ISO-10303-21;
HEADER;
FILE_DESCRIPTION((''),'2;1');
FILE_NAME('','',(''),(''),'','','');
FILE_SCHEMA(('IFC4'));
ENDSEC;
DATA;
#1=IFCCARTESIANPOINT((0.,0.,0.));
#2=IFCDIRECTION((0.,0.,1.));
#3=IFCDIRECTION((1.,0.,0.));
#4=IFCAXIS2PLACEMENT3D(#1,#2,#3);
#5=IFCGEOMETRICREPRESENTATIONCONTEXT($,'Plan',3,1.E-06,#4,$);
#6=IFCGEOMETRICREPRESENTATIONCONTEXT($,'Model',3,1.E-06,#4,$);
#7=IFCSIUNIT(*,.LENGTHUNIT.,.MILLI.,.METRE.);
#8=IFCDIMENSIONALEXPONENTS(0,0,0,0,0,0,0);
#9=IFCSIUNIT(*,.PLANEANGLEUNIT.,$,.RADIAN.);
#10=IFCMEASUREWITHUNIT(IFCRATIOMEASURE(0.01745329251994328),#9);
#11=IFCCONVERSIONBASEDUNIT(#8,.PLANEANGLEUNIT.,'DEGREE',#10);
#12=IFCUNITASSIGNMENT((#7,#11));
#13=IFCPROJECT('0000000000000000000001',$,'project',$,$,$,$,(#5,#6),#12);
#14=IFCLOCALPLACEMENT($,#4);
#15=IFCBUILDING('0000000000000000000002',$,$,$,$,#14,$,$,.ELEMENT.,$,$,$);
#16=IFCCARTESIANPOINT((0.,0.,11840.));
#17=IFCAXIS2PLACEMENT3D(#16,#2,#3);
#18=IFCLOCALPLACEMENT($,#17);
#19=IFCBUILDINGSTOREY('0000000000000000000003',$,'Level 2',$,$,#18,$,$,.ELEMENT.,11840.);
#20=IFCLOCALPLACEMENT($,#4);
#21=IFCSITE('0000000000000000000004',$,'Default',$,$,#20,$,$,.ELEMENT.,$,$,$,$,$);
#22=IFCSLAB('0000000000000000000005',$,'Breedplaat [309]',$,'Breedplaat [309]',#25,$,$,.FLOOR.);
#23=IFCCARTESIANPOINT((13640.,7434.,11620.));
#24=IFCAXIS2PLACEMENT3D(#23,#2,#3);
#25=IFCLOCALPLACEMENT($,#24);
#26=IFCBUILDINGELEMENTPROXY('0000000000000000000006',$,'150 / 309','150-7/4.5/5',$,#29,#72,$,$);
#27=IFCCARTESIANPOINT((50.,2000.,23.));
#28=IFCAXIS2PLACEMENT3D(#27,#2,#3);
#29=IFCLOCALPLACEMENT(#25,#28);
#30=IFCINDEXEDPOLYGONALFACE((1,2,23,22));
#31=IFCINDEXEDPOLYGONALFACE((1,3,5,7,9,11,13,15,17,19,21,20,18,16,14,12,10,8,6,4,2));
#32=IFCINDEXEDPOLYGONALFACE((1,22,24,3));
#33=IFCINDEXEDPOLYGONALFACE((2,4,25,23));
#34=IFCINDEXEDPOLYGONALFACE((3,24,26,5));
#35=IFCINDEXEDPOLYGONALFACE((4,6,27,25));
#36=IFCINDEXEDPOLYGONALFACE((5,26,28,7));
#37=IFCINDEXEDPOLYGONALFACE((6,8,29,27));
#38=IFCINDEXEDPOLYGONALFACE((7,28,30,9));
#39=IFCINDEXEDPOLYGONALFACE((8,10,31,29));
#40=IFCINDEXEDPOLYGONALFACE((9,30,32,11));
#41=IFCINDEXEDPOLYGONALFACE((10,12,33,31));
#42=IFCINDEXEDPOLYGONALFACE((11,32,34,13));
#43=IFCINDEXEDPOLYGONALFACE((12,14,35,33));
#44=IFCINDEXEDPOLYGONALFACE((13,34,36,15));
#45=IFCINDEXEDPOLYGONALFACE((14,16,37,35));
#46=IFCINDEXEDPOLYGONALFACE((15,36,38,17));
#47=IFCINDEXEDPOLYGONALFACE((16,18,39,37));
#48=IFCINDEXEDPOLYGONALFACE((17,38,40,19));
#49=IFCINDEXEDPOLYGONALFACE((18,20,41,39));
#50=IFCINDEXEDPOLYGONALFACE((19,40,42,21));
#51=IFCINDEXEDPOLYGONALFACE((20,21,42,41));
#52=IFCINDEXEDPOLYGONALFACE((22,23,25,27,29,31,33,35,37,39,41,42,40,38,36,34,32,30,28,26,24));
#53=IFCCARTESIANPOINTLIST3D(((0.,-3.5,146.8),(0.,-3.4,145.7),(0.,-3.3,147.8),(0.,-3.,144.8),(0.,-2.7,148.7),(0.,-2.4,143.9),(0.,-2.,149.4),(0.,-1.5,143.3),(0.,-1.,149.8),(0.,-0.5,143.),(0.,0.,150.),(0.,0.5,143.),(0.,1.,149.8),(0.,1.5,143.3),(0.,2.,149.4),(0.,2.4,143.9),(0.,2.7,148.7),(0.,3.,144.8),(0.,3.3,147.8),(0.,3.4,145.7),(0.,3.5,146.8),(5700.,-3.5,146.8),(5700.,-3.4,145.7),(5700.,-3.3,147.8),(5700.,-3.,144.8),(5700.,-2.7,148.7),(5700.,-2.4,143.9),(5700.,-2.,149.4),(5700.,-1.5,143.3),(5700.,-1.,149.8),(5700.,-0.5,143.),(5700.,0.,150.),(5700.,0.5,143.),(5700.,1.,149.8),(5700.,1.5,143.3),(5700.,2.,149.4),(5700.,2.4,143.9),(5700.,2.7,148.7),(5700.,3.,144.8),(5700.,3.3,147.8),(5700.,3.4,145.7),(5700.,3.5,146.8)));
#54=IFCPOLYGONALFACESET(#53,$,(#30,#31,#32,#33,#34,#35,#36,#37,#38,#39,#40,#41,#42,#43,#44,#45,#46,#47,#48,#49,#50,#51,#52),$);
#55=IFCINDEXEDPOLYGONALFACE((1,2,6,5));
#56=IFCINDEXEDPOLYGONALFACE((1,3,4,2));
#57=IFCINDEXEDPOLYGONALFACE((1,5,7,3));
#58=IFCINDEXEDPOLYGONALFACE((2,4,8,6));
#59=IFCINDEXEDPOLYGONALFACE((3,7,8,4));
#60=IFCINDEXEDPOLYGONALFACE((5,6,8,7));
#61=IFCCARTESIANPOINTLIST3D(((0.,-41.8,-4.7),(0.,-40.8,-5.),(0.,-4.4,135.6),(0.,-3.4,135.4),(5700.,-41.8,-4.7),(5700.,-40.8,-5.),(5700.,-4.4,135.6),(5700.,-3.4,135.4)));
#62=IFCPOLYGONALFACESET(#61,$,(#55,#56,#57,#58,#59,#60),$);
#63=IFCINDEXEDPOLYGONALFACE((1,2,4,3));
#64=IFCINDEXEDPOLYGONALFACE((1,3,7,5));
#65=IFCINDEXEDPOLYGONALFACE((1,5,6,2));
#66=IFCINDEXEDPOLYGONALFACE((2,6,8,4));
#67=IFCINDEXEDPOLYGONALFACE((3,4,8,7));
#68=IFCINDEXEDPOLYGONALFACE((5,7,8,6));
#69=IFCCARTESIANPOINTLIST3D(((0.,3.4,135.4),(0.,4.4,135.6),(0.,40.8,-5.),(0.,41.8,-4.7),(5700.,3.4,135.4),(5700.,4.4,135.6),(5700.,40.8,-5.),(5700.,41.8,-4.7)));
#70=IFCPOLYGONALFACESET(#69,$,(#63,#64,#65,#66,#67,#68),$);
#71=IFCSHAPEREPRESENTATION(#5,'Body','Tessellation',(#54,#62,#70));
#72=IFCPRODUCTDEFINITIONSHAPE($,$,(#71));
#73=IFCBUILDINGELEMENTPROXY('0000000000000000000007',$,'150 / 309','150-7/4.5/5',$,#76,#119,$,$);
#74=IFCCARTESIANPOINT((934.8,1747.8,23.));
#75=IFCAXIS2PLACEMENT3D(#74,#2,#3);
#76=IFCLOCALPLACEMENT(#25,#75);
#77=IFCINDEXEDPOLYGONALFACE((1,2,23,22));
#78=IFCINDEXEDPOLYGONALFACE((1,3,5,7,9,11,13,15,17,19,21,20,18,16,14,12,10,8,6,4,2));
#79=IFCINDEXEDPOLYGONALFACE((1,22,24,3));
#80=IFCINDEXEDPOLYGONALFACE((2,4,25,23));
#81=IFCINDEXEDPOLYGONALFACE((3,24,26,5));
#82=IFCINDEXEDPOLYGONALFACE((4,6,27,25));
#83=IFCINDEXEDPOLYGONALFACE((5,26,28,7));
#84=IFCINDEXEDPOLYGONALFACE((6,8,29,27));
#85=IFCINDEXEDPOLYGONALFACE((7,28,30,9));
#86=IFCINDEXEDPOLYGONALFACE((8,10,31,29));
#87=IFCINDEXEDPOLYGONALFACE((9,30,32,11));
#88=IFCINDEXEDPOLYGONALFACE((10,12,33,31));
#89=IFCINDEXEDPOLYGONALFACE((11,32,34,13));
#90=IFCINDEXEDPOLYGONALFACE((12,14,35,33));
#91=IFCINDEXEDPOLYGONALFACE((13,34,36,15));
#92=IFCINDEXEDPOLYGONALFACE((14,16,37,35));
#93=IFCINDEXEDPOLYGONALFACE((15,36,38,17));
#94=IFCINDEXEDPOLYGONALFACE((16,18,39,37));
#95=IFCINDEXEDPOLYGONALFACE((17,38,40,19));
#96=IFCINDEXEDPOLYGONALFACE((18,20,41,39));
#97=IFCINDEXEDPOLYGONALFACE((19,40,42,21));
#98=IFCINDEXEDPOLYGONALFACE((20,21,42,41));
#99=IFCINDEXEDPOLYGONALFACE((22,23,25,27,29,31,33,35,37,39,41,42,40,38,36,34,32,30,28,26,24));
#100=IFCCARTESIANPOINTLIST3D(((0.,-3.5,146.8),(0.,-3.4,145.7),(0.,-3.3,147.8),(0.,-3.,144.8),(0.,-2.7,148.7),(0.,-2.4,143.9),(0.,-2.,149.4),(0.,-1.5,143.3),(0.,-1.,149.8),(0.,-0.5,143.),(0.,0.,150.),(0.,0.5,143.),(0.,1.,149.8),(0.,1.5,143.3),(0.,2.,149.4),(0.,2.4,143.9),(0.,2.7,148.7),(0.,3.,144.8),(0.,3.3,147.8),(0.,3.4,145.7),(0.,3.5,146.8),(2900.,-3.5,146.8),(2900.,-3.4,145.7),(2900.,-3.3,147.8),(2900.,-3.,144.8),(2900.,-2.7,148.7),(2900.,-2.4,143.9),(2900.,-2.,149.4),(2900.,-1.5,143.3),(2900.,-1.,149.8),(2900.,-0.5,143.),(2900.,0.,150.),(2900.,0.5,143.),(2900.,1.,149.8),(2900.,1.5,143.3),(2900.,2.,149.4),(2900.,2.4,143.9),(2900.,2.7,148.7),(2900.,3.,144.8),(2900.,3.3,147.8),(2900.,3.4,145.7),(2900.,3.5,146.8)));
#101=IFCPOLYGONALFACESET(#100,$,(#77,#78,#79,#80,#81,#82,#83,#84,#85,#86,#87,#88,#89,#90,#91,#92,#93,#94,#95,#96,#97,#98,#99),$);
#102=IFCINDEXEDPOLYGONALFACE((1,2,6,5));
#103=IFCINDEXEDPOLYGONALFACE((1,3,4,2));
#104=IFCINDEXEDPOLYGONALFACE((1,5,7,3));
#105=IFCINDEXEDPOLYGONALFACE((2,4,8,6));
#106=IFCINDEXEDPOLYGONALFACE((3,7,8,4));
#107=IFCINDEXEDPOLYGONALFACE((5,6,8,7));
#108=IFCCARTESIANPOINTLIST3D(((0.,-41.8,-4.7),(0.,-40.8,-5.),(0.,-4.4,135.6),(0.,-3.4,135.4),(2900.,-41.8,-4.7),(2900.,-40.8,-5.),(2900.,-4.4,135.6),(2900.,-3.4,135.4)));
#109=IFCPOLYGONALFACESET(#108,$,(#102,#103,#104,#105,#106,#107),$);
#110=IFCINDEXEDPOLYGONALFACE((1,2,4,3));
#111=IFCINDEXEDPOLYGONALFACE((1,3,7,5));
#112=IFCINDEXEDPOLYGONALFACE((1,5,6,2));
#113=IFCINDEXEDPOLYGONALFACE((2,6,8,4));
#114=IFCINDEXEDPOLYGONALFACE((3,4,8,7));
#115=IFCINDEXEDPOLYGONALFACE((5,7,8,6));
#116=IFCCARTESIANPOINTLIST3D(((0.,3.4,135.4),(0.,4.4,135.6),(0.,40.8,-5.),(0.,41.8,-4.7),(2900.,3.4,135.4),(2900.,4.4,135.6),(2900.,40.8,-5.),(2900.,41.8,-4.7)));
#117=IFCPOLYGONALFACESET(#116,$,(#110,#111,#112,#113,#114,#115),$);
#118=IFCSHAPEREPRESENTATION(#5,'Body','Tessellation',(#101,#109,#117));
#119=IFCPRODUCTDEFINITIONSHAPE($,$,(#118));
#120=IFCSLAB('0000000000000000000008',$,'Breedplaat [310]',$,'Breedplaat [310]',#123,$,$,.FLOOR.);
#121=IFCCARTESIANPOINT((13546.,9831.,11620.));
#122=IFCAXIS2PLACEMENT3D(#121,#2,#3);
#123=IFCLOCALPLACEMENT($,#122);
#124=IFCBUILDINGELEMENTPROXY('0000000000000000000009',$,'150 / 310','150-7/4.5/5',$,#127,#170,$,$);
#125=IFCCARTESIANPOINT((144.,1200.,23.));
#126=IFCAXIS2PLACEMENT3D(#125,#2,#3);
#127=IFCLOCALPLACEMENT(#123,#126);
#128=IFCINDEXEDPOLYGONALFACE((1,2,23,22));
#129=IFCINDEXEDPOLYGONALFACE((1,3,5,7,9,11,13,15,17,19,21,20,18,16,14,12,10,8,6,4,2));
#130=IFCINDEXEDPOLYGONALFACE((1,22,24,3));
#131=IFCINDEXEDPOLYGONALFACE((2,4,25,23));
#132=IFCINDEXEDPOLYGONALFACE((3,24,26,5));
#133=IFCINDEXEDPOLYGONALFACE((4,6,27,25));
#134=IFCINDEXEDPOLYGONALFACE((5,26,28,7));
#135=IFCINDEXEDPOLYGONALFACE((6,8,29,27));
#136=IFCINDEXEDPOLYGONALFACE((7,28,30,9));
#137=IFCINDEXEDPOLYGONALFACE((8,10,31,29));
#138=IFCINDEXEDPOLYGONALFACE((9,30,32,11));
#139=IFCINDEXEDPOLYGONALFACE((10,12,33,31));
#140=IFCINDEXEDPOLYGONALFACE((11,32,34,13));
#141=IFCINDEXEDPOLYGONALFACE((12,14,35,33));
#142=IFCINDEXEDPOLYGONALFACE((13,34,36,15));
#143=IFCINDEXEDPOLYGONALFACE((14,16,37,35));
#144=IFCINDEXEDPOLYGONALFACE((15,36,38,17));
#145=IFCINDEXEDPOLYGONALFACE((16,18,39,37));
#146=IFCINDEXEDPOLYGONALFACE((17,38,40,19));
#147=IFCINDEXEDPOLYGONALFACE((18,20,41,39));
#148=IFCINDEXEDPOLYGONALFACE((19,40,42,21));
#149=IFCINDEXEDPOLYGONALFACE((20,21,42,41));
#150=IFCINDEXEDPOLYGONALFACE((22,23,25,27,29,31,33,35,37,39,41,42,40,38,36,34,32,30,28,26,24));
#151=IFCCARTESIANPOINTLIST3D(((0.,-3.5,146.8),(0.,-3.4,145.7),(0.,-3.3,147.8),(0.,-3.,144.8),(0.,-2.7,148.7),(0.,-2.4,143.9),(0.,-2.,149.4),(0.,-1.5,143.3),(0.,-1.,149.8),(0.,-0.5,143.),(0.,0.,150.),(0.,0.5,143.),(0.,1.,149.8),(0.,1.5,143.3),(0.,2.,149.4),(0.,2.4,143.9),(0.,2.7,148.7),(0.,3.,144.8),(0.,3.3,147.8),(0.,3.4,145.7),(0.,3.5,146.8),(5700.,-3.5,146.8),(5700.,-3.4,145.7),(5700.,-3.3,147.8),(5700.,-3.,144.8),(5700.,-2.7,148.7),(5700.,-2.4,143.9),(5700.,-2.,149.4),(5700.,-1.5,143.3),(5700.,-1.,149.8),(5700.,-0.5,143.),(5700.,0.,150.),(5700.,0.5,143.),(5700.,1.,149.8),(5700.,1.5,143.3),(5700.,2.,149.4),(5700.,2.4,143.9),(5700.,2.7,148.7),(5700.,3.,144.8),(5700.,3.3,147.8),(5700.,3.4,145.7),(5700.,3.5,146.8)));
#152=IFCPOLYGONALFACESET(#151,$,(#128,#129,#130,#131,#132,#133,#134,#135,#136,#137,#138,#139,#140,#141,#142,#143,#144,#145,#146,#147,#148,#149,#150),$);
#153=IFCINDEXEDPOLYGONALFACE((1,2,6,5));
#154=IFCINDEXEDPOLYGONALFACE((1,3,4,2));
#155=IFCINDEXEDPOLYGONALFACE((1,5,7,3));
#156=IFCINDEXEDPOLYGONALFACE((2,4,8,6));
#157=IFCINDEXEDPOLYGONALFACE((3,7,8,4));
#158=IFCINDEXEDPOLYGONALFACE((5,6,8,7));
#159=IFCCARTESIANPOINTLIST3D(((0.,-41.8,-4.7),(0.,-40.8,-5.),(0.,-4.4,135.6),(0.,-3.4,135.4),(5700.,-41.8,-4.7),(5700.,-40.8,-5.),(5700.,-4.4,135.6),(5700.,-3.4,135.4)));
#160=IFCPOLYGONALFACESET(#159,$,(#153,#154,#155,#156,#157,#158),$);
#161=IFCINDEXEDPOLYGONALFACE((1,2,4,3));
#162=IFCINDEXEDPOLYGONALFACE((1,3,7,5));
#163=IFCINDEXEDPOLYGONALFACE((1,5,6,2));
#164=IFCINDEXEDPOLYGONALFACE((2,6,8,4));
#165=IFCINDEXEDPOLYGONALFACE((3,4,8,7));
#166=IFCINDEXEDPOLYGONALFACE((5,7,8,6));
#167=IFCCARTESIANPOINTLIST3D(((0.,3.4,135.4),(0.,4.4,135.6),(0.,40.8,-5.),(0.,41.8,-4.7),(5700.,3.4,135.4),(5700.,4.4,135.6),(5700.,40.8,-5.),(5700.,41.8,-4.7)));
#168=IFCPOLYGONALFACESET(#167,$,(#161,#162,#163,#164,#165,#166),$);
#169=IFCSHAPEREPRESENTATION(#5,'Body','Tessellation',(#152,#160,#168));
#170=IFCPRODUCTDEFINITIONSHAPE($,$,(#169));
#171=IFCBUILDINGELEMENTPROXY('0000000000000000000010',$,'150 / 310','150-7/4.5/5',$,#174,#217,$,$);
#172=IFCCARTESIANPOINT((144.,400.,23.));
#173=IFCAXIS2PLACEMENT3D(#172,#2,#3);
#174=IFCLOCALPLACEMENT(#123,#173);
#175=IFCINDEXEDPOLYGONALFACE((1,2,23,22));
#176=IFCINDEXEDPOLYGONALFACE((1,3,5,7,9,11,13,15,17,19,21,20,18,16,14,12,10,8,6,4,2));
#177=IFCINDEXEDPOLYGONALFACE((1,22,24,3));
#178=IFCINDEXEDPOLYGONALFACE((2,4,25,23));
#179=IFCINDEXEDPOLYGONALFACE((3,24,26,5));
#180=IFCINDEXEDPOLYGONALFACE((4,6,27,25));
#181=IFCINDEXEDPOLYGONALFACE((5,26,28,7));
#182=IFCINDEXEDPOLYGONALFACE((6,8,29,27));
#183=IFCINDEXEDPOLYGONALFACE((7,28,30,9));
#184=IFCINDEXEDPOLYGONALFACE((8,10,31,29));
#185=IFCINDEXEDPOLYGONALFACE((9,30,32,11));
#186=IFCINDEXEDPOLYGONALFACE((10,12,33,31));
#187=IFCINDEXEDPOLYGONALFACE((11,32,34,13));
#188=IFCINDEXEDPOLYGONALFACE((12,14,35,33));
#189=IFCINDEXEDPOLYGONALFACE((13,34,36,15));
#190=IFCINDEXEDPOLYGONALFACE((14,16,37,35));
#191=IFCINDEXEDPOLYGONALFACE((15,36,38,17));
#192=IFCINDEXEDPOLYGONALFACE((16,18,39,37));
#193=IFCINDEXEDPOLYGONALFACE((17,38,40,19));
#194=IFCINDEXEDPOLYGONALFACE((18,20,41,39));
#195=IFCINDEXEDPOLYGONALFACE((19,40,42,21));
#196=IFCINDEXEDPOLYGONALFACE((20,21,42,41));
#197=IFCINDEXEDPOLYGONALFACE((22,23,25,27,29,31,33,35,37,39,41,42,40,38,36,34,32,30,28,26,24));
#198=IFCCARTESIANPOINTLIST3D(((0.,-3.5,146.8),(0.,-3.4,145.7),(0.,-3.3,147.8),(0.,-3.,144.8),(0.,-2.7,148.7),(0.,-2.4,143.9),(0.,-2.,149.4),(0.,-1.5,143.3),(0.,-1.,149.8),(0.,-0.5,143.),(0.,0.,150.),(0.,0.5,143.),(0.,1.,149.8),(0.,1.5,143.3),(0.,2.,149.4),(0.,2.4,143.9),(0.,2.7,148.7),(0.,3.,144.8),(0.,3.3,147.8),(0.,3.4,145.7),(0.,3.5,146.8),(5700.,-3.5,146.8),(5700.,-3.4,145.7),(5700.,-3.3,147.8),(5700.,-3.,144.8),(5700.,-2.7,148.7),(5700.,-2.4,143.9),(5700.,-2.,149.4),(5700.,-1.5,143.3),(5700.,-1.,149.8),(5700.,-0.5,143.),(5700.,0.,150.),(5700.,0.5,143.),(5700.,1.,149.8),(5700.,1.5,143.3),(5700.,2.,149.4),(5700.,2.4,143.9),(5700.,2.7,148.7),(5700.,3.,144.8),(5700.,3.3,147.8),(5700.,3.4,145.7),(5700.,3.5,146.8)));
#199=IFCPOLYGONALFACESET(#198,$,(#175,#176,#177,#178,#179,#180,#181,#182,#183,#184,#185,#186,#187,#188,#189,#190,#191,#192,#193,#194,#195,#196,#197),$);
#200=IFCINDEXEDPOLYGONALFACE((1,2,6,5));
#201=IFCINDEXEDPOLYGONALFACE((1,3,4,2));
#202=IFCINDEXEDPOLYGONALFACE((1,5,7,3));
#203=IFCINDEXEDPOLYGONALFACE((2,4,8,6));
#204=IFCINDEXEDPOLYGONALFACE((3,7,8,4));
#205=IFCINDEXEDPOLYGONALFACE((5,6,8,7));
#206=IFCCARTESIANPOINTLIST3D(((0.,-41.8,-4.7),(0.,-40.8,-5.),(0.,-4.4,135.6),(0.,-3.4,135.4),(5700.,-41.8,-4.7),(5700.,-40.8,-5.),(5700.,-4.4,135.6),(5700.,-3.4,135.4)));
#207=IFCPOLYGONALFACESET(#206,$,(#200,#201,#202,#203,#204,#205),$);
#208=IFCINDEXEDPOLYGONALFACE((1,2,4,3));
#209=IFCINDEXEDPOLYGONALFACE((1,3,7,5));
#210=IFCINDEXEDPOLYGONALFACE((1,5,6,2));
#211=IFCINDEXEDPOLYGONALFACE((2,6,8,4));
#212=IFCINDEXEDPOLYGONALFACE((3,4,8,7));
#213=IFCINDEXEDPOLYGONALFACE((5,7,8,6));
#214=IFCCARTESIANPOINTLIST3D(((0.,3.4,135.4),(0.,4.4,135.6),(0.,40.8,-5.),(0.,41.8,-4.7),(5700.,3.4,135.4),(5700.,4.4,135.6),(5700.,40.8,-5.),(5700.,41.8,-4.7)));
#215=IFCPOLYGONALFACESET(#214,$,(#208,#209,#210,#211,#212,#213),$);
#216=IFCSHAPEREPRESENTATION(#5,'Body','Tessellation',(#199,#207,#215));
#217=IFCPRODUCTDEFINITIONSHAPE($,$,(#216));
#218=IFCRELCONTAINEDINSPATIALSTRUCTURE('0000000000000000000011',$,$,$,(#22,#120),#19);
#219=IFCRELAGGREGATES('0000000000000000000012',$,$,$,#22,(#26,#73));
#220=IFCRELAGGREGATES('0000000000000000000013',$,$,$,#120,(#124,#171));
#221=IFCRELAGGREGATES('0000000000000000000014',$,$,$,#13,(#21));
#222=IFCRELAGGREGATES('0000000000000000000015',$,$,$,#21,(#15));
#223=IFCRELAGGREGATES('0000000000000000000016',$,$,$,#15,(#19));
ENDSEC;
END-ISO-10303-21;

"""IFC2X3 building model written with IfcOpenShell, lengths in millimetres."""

from ifc_helpers import new_model, entity, si_unit, converted_unit, frame, origin_with_axes, origin_2d_with_axis, place, context, project, spatial, rectangle, circle, extrude, element, aggregate, save


model = new_model("IFC2X3")

# Units and contexts
plan_context = context("Plan", 3, precision=1e-06, world=origin_with_axes())
model_context = context("Model", 3, precision=1e-06, world=origin_with_axes())
ifc_project = project(units=[si_unit("LENGTHUNIT", "METRE", prefix="MILLI"), converted_unit("PLANEANGLEUNIT", "DEGREE", entity("IfcRatioMeasure", 0.01745329251994328), si_unit("PLANEANGLEUNIT", "RADIAN"), dimensions=[0, 0, 0, 0, 0, 0, 0])], contexts=[plan_context, model_context])

# Site, building, storey
site_placement = place(None, origin_with_axes())
site = spatial("IfcSite", under=ifc_project, at=site_placement, Name="Default", CompositionType="ELEMENT")
building_placement = place(None, origin_with_axes())
building = spatial("IfcBuilding", under=site, at=building_placement, CompositionType="ELEMENT")
storey_placement = place(None, frame((0.0, 0.0, 11840.0), z_axis=(0.0, 0.0, 1.0), x_axis=(1.0, 0.0, 0.0)))
storey = spatial("IfcBuildingStorey", under=building, at=storey_placement, Name="Level 2", CompositionType="ELEMENT", Elevation=11840.0)

# Slab, building element proxies
slab_1_placement = place(None, frame((13640.0, 7434.0, 11620.0), z_axis=(0.0, 0.0, 1.0), x_axis=(1.0, 0.0, 0.0)))
slab_1 = element("IfcSlab", 1, at=slab_1_placement, inside=storey, Name="Breedplaat [309]", ObjectType="Breedplaat [309]", PredefinedType="FLOOR")
proxy_1_placement = place(slab_1_placement, frame((50.0, 2000.0, 23.0), z_axis=(0.0, 0.0, 1.0), x_axis=(1.0, 0.0, 0.0)))
proxy_1 = element("IfcBuildingElementProxy", 2, at=proxy_1_placement, Name="150 / 309", Description="150-7/4.5/5", context=plan_context, shape_type="SweptSolid", body=[
    extrude(circle(Radius=3.5, at=origin_2d_with_axis()), frame((0.0, 0.0, 146.5), z_axis=(1.0, 0.0, 0.0), x_axis=(0.0, 0.0, 1.0)), (0.0, 0.0, 1.0), 5700.0),
    extrude(rectangle(XDim=145.2, YDim=1.0, at=origin_2d_with_axis()), frame((0.0, -22.6, 65.3), z_axis=(1.0, 0.0, 0.0), x_axis=(0.0, 0.257663, 0.966235)), (0.0, 0.0, 1.0), 5700.0),
    extrude(rectangle(XDim=145.2, YDim=1.0, at=origin_2d_with_axis()), frame((0.0, 22.6, 65.3), z_axis=(1.0, 0.0, 0.0), x_axis=(0.0, -0.257663, 0.966235)), (0.0, 0.0, 1.0), 5700.0),
])
proxy_2_placement = place(slab_1_placement, frame((934.8, 1747.8, 23.0), z_axis=(0.0, 0.0, 1.0), x_axis=(1.0, 0.0, 0.0)))
proxy_2 = element("IfcBuildingElementProxy", 3, at=proxy_2_placement, Name="150 / 309", Description="150-7/4.5/5", context=plan_context, shape_type="SweptSolid", body=[
    extrude(circle(Radius=3.5, at=origin_2d_with_axis()), frame((0.0, 0.0, 146.5), z_axis=(1.0, 0.0, 0.0), x_axis=(0.0, 0.0, 1.0)), (0.0, 0.0, 1.0), 2900.0),
    extrude(rectangle(XDim=145.2, YDim=1.0, at=origin_2d_with_axis()), frame((0.0, -22.6, 65.3), z_axis=(1.0, 0.0, 0.0), x_axis=(0.0, 0.257663, 0.966235)), (0.0, 0.0, 1.0), 2900.0),
    extrude(rectangle(XDim=145.2, YDim=1.0, at=origin_2d_with_axis()), frame((0.0, 22.6, 65.3), z_axis=(1.0, 0.0, 0.0), x_axis=(0.0, -0.257663, 0.966235)), (0.0, 0.0, 1.0), 2900.0),
])
aggregate(slab_1, [proxy_1, proxy_2])

# Slab, building element proxies
slab_2_placement = place(None, frame((13546.0, 9831.0, 11620.0), z_axis=(0.0, 0.0, 1.0), x_axis=(1.0, 0.0, 0.0)))
slab_2 = element("IfcSlab", 4, at=slab_2_placement, inside=storey, Name="Breedplaat [310]", ObjectType="Breedplaat [310]", PredefinedType="FLOOR")
proxy_3_placement = place(slab_2_placement, frame((144.0, 1200.0, 23.0), z_axis=(0.0, 0.0, 1.0), x_axis=(1.0, 0.0, 0.0)))
proxy_3 = element("IfcBuildingElementProxy", 5, at=proxy_3_placement, Name="150 / 310", Description="150-7/4.5/5", context=plan_context, shape_type="SweptSolid", body=[
    extrude(circle(Radius=3.5, at=origin_2d_with_axis()), frame((0.0, 0.0, 146.5), z_axis=(1.0, 0.0, 0.0), x_axis=(0.0, 0.0, 1.0)), (0.0, 0.0, 1.0), 5700.0),
    extrude(rectangle(XDim=145.2, YDim=1.0, at=origin_2d_with_axis()), frame((0.0, -22.6, 65.3), z_axis=(1.0, 0.0, 0.0), x_axis=(0.0, 0.257663, 0.966235)), (0.0, 0.0, 1.0), 5700.0),
    extrude(rectangle(XDim=145.2, YDim=1.0, at=origin_2d_with_axis()), frame((0.0, 22.6, 65.3), z_axis=(1.0, 0.0, 0.0), x_axis=(0.0, -0.257663, 0.966235)), (0.0, 0.0, 1.0), 5700.0),
])
proxy_4_placement = place(slab_2_placement, frame((144.0, 400.0, 23.0), z_axis=(0.0, 0.0, 1.0), x_axis=(1.0, 0.0, 0.0)))
proxy_4 = element("IfcBuildingElementProxy", 6, at=proxy_4_placement, Name="150 / 310", Description="150-7/4.5/5", context=plan_context, shape_type="SweptSolid", body=[
    extrude(circle(Radius=3.5, at=origin_2d_with_axis()), frame((0.0, 0.0, 146.5), z_axis=(1.0, 0.0, 0.0), x_axis=(0.0, 0.0, 1.0)), (0.0, 0.0, 1.0), 5700.0),
    extrude(rectangle(XDim=145.2, YDim=1.0, at=origin_2d_with_axis()), frame((0.0, -22.6, 65.3), z_axis=(1.0, 0.0, 0.0), x_axis=(0.0, 0.257663, 0.966235)), (0.0, 0.0, 1.0), 5700.0),
    extrude(rectangle(XDim=145.2, YDim=1.0, at=origin_2d_with_axis()), frame((0.0, 22.6, 65.3), z_axis=(1.0, 0.0, 0.0), x_axis=(0.0, -0.257663, 0.966235)), (0.0, 0.0, 1.0), 5700.0),
])
aggregate(slab_2, [proxy_3, proxy_4])

save(model, "model.ifc")
